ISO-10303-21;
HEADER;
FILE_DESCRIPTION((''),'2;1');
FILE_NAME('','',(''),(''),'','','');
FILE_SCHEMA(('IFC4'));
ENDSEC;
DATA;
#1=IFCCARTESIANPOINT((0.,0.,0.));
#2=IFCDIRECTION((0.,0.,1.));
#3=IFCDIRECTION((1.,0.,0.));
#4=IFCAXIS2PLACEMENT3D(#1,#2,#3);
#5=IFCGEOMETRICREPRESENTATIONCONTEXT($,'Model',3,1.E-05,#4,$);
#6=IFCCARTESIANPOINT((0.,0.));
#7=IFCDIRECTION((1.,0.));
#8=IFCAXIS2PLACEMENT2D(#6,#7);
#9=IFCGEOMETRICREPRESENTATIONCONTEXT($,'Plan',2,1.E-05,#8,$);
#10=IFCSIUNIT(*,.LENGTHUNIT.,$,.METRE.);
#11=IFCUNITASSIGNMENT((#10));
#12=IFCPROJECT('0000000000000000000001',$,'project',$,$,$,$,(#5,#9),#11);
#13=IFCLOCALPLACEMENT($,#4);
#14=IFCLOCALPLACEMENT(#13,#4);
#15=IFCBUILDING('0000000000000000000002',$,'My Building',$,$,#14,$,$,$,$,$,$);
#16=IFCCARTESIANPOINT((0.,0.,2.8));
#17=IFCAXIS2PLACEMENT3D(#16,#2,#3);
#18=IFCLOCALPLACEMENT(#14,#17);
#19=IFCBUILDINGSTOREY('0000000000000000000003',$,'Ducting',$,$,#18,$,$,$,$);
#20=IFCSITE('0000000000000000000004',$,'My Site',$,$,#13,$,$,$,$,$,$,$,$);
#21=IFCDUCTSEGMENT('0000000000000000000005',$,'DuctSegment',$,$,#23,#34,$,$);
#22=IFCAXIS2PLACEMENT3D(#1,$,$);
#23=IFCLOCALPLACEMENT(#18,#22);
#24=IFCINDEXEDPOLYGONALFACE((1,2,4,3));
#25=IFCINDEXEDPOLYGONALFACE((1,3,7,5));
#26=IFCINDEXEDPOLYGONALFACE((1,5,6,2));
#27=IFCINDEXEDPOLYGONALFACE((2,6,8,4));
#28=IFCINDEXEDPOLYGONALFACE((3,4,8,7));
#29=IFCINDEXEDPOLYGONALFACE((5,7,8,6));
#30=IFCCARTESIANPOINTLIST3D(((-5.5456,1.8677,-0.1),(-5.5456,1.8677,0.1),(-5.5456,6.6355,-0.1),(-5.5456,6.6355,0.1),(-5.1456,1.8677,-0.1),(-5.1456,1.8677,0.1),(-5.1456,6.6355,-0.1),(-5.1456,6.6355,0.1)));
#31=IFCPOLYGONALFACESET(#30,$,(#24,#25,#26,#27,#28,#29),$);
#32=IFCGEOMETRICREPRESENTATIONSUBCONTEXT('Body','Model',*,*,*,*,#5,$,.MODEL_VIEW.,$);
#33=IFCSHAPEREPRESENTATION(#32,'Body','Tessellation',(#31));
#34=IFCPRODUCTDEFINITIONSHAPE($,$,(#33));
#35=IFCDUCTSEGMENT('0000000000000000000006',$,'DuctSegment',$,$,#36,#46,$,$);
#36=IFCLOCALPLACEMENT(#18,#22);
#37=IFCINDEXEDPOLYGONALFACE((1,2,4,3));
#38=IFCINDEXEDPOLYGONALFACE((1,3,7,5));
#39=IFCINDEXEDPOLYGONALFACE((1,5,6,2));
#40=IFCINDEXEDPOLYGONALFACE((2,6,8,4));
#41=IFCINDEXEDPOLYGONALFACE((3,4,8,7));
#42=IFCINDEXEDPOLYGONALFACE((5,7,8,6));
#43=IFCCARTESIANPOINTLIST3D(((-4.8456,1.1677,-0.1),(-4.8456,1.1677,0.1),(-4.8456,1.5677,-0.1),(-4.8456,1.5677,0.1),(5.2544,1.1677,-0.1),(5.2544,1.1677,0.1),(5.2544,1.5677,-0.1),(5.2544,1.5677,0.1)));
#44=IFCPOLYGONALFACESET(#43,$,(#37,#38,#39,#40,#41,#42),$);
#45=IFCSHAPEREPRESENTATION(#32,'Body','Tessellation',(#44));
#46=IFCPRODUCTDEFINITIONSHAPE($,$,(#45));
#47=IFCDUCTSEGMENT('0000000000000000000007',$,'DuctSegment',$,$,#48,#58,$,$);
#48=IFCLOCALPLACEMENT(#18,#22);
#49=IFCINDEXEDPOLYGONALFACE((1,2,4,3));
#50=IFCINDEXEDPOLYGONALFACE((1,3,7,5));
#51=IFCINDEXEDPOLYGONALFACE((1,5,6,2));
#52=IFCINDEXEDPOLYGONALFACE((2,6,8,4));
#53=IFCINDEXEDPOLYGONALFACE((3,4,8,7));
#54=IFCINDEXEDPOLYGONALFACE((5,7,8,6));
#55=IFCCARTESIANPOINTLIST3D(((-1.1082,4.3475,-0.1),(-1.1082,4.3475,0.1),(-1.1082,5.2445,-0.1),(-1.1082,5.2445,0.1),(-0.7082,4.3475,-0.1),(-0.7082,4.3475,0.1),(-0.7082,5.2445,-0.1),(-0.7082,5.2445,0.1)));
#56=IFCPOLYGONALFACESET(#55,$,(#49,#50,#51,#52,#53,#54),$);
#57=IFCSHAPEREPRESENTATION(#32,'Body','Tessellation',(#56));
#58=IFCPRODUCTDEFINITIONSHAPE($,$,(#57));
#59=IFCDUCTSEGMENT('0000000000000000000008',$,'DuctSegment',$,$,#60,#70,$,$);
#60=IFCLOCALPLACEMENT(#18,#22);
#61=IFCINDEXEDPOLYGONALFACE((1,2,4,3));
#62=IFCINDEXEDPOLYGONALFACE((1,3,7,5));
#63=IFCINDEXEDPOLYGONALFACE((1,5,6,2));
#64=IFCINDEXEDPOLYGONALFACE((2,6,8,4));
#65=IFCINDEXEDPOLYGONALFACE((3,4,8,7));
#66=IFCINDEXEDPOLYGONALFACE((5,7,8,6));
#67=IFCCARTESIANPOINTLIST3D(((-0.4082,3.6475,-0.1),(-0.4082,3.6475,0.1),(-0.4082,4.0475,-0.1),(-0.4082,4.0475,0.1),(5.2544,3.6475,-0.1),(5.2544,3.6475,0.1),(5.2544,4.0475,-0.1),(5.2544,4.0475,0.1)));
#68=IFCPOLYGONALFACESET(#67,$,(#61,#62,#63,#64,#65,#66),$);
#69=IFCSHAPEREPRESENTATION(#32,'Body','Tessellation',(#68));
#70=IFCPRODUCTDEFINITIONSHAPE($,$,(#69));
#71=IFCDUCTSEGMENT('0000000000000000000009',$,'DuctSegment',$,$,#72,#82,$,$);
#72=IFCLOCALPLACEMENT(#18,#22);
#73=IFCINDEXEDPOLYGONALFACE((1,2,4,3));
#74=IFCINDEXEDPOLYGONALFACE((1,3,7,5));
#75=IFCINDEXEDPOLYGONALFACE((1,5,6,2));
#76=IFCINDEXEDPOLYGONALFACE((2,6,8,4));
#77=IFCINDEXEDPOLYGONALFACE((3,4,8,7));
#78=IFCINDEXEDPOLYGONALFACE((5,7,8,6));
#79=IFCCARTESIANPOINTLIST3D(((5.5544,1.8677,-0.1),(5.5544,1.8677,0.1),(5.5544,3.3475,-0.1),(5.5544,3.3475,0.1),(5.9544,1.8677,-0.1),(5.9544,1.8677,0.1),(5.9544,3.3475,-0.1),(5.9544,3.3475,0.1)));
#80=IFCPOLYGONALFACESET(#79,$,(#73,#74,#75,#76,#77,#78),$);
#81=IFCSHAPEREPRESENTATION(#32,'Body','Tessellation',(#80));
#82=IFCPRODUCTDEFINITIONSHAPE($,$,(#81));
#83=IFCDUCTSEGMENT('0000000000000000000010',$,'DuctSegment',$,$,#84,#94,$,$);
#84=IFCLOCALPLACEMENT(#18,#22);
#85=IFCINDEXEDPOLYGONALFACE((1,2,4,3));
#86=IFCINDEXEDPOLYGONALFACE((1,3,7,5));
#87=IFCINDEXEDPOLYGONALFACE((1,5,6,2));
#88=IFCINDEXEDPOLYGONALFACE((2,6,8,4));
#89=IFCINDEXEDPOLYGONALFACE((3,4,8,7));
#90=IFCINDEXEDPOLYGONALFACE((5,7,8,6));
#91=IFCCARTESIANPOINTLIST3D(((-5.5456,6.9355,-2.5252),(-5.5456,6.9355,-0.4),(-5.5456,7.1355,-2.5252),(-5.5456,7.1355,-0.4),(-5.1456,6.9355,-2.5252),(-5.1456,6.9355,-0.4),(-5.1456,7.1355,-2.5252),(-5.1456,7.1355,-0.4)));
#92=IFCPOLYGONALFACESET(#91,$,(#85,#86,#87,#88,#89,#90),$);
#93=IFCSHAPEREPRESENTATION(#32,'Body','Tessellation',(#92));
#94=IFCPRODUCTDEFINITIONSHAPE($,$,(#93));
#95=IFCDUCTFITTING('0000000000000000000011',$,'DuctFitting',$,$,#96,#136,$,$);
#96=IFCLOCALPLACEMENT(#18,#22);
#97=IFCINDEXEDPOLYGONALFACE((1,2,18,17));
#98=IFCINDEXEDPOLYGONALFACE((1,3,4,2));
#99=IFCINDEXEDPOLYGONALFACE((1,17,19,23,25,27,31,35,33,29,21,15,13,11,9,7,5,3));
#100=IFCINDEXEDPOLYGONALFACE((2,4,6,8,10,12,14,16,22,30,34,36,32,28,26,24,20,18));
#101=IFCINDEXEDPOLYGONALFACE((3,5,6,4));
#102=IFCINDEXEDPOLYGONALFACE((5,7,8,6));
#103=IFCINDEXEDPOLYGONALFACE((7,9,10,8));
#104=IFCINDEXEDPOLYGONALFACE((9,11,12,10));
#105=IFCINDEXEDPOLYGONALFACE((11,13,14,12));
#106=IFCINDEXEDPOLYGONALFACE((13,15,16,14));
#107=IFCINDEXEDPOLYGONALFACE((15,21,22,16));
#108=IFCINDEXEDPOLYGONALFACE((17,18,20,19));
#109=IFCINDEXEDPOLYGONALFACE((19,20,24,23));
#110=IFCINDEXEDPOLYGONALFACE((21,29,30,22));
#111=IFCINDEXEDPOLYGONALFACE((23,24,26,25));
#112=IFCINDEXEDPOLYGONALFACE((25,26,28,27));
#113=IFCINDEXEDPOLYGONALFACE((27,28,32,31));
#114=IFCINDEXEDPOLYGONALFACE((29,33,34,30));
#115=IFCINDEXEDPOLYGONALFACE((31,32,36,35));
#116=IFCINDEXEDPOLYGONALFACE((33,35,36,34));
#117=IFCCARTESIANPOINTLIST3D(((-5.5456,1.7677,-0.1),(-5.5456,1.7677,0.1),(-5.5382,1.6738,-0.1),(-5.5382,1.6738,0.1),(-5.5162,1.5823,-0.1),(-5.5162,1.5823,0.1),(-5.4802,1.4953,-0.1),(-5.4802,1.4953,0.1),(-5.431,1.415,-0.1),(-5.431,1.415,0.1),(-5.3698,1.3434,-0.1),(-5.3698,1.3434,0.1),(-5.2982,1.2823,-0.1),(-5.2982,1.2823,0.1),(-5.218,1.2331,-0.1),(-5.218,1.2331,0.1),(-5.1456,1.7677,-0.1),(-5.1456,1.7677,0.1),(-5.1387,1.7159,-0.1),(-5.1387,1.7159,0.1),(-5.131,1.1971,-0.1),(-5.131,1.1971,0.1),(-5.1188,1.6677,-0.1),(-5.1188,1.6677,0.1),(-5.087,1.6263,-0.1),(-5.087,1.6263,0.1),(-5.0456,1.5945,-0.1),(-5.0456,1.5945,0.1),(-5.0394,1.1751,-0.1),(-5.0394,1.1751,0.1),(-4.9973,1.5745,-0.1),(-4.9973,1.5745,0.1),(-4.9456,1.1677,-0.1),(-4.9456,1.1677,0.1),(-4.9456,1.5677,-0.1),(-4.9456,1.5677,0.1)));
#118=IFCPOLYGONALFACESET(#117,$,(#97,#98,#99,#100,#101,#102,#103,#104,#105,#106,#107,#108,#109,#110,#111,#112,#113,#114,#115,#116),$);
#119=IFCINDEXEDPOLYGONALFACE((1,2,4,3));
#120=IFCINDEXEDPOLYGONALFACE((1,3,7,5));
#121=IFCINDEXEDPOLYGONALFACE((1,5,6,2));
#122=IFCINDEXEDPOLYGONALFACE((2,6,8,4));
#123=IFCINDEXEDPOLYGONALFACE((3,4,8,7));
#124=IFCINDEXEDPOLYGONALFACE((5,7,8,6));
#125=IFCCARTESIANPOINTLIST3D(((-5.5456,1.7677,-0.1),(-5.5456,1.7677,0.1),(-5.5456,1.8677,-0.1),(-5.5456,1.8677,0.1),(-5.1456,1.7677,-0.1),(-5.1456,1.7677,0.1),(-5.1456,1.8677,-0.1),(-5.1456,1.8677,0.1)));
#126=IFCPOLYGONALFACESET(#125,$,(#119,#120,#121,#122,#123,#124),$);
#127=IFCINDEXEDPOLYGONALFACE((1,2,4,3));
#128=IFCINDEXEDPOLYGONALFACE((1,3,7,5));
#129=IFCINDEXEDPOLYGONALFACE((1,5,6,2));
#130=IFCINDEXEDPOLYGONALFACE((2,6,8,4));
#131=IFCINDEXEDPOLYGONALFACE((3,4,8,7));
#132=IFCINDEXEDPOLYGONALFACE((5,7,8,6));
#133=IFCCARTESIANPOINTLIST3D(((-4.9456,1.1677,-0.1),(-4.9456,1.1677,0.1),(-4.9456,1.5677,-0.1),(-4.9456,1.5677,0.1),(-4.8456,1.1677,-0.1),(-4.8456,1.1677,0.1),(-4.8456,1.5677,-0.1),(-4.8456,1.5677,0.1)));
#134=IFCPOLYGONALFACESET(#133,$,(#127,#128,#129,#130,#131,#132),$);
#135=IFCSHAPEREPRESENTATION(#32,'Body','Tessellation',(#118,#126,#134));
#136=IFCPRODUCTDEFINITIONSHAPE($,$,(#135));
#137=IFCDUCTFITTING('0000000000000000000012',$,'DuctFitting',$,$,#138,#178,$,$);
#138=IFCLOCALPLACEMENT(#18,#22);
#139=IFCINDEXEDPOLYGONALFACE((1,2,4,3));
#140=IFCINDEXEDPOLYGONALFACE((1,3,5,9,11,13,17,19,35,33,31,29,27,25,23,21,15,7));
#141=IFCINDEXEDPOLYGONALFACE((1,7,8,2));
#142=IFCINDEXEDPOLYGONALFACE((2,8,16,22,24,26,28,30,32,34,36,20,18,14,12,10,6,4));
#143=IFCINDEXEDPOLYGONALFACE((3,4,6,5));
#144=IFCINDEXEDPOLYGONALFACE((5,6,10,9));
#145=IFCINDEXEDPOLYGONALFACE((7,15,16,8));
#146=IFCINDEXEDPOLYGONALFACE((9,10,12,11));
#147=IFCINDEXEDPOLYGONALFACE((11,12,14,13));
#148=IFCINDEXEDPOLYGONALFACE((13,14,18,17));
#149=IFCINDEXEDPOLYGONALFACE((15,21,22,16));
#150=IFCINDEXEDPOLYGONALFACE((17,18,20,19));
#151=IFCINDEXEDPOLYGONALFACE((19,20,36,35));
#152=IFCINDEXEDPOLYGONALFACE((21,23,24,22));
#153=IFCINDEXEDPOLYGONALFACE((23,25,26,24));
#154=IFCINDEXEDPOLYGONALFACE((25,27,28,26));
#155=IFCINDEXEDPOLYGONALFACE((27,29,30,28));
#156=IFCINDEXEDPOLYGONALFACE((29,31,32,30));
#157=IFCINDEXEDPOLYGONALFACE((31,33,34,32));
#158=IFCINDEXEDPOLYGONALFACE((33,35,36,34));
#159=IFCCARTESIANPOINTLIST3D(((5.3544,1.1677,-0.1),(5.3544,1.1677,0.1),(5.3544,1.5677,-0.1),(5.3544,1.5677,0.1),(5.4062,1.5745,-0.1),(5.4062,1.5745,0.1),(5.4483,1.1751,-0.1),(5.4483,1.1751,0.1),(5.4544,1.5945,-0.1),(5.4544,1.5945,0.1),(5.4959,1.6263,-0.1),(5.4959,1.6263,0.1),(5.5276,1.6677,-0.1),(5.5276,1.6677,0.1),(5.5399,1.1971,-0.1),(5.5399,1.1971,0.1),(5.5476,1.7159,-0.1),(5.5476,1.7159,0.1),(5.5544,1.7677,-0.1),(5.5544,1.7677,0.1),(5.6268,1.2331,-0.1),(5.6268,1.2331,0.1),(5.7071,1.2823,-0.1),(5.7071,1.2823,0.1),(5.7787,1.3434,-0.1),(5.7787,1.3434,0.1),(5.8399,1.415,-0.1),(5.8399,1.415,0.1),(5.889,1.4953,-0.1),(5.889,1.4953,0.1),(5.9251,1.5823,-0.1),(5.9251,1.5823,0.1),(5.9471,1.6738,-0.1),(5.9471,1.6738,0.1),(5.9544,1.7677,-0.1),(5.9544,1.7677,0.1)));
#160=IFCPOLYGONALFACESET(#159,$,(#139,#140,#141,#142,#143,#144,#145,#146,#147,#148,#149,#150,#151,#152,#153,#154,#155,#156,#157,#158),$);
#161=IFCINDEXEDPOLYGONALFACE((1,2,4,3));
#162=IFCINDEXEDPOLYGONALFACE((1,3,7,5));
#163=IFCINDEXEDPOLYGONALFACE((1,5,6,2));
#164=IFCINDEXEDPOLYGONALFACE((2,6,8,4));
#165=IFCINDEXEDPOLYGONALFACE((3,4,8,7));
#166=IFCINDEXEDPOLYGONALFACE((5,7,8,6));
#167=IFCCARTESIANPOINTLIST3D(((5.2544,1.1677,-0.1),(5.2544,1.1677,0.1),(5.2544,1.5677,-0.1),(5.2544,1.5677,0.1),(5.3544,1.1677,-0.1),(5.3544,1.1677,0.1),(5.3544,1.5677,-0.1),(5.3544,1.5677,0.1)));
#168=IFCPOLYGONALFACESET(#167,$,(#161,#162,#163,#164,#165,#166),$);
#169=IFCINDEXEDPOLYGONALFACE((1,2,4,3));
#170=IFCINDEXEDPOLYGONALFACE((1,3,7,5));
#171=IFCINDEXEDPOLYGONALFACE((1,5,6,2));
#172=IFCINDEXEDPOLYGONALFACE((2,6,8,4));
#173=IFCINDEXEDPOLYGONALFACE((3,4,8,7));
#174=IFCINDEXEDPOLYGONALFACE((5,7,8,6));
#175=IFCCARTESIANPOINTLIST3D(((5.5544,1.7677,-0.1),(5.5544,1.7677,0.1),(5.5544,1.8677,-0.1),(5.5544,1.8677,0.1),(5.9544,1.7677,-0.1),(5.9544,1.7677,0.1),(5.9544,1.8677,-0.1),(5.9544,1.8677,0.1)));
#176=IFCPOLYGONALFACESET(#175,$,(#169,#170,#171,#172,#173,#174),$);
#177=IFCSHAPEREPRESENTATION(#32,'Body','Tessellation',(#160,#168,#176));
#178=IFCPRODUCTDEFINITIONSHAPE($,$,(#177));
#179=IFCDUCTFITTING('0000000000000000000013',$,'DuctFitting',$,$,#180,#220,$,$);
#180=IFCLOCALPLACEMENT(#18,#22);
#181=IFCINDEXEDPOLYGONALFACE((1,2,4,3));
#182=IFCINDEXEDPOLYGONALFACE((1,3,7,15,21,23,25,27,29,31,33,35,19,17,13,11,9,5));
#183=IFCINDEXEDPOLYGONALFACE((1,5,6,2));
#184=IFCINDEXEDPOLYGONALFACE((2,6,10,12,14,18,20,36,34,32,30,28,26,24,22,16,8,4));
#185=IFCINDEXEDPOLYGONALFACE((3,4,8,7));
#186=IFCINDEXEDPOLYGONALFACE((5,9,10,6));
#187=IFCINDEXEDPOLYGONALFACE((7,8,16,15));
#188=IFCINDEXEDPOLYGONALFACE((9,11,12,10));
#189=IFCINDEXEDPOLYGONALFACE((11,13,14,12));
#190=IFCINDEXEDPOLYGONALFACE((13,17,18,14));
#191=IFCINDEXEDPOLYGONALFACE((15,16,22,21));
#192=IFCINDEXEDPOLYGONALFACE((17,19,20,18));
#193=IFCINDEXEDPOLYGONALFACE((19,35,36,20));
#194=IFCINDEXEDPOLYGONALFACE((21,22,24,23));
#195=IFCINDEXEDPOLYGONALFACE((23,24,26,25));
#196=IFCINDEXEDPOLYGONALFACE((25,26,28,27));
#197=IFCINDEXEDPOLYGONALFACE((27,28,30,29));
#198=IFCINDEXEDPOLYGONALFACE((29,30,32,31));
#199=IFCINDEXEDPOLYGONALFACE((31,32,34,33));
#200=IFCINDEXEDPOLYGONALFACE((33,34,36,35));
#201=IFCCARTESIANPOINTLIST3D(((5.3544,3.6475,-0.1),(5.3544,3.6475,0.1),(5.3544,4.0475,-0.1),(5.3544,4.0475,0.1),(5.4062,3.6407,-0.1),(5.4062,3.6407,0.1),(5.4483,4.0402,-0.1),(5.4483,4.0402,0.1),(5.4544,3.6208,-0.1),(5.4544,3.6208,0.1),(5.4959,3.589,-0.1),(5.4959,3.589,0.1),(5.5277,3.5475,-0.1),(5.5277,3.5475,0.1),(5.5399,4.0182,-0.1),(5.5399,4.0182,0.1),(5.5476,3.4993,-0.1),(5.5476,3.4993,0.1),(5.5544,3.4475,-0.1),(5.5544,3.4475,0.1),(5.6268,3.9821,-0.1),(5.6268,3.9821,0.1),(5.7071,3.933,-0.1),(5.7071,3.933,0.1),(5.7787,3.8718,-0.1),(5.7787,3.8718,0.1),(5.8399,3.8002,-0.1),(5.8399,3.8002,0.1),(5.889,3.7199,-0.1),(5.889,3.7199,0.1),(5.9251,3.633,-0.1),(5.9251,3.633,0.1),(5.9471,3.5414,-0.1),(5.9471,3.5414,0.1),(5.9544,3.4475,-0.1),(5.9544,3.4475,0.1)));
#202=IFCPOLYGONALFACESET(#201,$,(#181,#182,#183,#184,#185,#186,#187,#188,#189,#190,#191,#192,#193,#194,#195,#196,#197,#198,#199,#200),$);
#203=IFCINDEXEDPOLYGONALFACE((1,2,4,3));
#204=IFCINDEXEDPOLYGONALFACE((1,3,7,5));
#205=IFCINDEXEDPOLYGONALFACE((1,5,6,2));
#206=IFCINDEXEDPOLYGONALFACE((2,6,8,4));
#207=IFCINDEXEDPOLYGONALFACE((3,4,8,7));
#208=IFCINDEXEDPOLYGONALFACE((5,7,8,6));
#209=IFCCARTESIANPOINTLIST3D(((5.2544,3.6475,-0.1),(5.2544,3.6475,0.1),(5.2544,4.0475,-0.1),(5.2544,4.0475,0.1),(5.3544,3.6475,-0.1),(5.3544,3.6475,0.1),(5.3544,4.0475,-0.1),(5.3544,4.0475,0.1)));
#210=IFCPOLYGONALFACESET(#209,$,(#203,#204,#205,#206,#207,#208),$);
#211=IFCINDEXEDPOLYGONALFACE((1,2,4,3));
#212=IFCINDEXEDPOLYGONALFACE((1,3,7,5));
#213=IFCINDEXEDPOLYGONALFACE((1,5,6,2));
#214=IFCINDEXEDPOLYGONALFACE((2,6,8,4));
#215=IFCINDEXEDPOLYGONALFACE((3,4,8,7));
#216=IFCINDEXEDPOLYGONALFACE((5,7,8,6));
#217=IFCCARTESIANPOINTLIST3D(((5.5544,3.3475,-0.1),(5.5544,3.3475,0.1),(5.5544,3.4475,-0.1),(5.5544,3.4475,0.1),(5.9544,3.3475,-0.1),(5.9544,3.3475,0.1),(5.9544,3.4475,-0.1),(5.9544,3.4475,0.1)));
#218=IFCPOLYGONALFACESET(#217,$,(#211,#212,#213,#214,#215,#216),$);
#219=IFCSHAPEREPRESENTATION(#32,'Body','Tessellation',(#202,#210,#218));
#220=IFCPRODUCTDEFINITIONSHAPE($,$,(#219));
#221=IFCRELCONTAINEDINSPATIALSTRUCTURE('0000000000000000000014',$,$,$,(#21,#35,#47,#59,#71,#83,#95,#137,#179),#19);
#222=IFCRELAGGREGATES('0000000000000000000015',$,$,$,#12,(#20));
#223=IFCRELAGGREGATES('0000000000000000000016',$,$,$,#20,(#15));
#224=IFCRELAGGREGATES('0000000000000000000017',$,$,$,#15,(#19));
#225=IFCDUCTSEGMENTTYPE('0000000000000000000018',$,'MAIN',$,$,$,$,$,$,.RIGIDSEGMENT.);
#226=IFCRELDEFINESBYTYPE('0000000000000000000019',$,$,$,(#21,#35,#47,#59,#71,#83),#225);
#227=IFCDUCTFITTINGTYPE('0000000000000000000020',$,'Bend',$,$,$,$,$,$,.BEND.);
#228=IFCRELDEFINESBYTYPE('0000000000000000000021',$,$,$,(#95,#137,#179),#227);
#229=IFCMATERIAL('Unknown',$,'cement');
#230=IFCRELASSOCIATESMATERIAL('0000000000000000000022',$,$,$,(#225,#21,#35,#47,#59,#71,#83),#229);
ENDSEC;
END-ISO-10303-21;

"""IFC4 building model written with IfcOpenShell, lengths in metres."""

from ifc_helpers import new_model, si_unit, frame, origin_with_axes, origin_2d_with_axis, place, context, subcontext, project, spatial, line, arc, indexed_curve, rectangle, outline, extrude, source, transform, mapped, material, material_profile, profile_set, profile_usage, type_object, type_shapes, element, save


model = new_model("IFC4")

# Units and contexts
model_context = context("Model", 3, precision=1e-05, world=origin_with_axes())
plan_context = context("Plan", 2, precision=1e-05, world=origin_2d_with_axis())
body_context = subcontext(model_context, "Body", "Model", "MODEL_VIEW")
ifc_project = project(units=[si_unit("LENGTHUNIT", "METRE")], contexts=[model_context, plan_context])

# Site, building, storey
site_placement = place(None, origin_with_axes())
site = spatial("IfcSite", under=ifc_project, at=site_placement, Name="My Site")
building_placement = place(site_placement, origin_with_axes())
building = spatial("IfcBuilding", under=site, at=building_placement, Name="My Building")
storey_placement = place(building_placement, frame((0.0, 0.0, 2.8), z_axis=(0.0, 0.0, 1.0), x_axis=(1.0, 0.0, 0.0)))
storey = spatial("IfcBuildingStorey", under=building, at=storey_placement, Name="Ducting")

# Duct segments
ifc_material = material(Name="Unknown", Category="cement")
ifc_material_profile_1 = material_profile(ifc_material, rectangle(XDim=0.4, YDim=0.2))
ifc_profile_set_1 = profile_set([ifc_material_profile_1])
ifc_profile_usage_1 = profile_usage(ifc_profile_set_1, cardinal=5)
duct_segment_type_1 = type_object("IfcDuctSegmentType", Name="MAIN", PredefinedType="RIGIDSEGMENT", material=ifc_profile_set_1)
duct_segment_1_placement = place(storey_placement, frame((-5.3456, 6.6355, 0.0), z_axis=(0.0, -1.0, 0.0), x_axis=(1.0, 0.0, 0.0)))
element("IfcDuctSegment", 1, at=duct_segment_1_placement, inside=storey, type_object=duct_segment_type_1, material=ifc_profile_usage_1, Name="DuctSegment", context=body_context, shape_type="SweptSolid", body=[
    extrude(rectangle(XDim=0.4, YDim=0.2), origin_with_axes(), (0.0, 0.0, 1.0), 4.7678),
])
ifc_profile_usage_2 = profile_usage(ifc_profile_set_1, cardinal=5)
duct_segment_2_placement = place(storey_placement, frame((-4.8456, 1.3677, 0.0), z_axis=(1.0, -0.000001, 0.000001), x_axis=(0.000001, 1.0, 0.0)))
element("IfcDuctSegment", 2, at=duct_segment_2_placement, inside=storey, type_object=duct_segment_type_1, material=ifc_profile_usage_2, Name="DuctSegment", context=body_context, shape_type="SweptSolid", body=[
    extrude(rectangle(XDim=0.4, YDim=0.2), origin_with_axes(), (0.0, 0.0, 1.0), 10.1),
])
ifc_profile_usage_3 = profile_usage(ifc_profile_set_1, cardinal=5)
duct_segment_3_placement = place(storey_placement, frame((-0.9082, 5.2445, 0.0), z_axis=(0.0, -1.0, 0.0), x_axis=(1.0, 0.0, 0.0)))
element("IfcDuctSegment", 3, at=duct_segment_3_placement, inside=storey, type_object=duct_segment_type_1, material=ifc_profile_usage_3, Name="DuctSegment", context=body_context, shape_type="SweptSolid", body=[
    extrude(rectangle(XDim=0.4, YDim=0.2), origin_with_axes(), (0.0, 0.0, 1.0), 0.897),
])
ifc_profile_usage_4 = profile_usage(ifc_profile_set_1, cardinal=5)
duct_segment_4_placement = place(storey_placement, frame((-0.4082, 3.8475, 0.0), z_axis=(1.0, 0.0, 0.0), x_axis=(0.0, 1.0, 0.0)))
element("IfcDuctSegment", 4, at=duct_segment_4_placement, inside=storey, type_object=duct_segment_type_1, material=ifc_profile_usage_4, Name="DuctSegment", context=body_context, shape_type="SweptSolid", body=[
    extrude(rectangle(XDim=0.4, YDim=0.2), origin_with_axes(), (0.0, 0.0, 1.0), 5.6627),
])
ifc_profile_usage_5 = profile_usage(ifc_profile_set_1, cardinal=5)
duct_segment_5_placement = place(storey_placement, frame((5.7544, 3.3475, 0.0), z_axis=(0.0, -1.0, 0.0), x_axis=(1.0, 0.0, 0.0)))
element("IfcDuctSegment", 5, at=duct_segment_5_placement, inside=storey, type_object=duct_segment_type_1, material=ifc_profile_usage_5, Name="DuctSegment", context=body_context, shape_type="SweptSolid", body=[
    extrude(rectangle(XDim=0.4, YDim=0.2), origin_with_axes(), (0.0, 0.0, 1.0), 1.4799),
])
ifc_profile_usage_6 = profile_usage(ifc_profile_set_1, cardinal=5)
duct_segment_6_placement = place(storey_placement, frame((-5.3456, 7.0355, -0.4), z_axis=(0.0, 0.0, -1.0), x_axis=(1.0, 0.0, 0.0)))
element("IfcDuctSegment", 6, at=duct_segment_6_placement, inside=storey, type_object=duct_segment_type_1, material=ifc_profile_usage_6, Name="DuctSegment", context=body_context, shape_type="SweptSolid", body=[
    extrude(rectangle(XDim=0.4, YDim=0.2), origin_with_axes(), (0.0, 0.0, 1.0), 2.1252),
])

# Duct fittings
duct_fitting_type_1 = type_object("IfcDuctFittingType", Name="Bend", PredefinedType="BEND")
shared_shape = source(origin_with_axes(), body_context, "Body", "SweptSolid", [
    extrude(outline(indexed_curve([(0.2, 0.0), (0.2586, 0.1414), (0.4, 0.2), (0.4, 0.6), (-0.0243, 0.4243), (-0.2, 0.0)], segments=[arc(1, 2, 3), line(3, 4), arc(4, 5, 6), line(6, 1)])), frame((0.0, -0.1, 0.1), z_axis=(0.0, -1.0, 0.0), x_axis=(1.0, 0.0, 0.0)), (0.0, 0.0, -1.0), 0.2),
    extrude(rectangle(XDim=0.4, YDim=0.2), origin_with_axes(), (0.0, 0.0, 1.0), 0.1),
    extrude(rectangle(XDim=0.4, YDim=0.2), frame((0.4, 0.0, 0.5), z_axis=(1.0, 0.0, 0.000001), x_axis=(-0.000001, 0.0, 1.0)), (0.0, 0.0, 1.0), 0.1),
])
type_shapes(duct_fitting_type_1, [shared_shape])
for number, where, z_axis, x_axis, name in (
    (7, (-5.3456, 1.8677, 0.0), (0.0, -1.0, 0.0), (1.0, 0.0, 0.0), "DuctFitting"),
    (8, (5.2544, 1.3677, 0.0), (1.0, -0.000001, 0.000001), (0.000001, 1.0, 0.0), "DuctFitting"),
    (9, (5.2544, 3.8475, 0.0), (1.0, 0.0, 0.0), (0.0, -1.0, 0.0), "DuctFitting"),
):
    element("IfcDuctFitting", number, at=place(storey_placement, frame(where, z_axis=z_axis, x_axis=x_axis)), inside=storey, type_object=duct_fitting_type_1, Name=name, context=body_context, shape_type="MappedRepresentation", body=[
        mapped(shared_shape, transform((0.0, 0.0, 0.0), x_axis=(1.0, 0.0, 0.0), y_axis=(0.0, 1.0, 0.0), z_axis=(0.0, 0.0, 1.0), scale=1.0)),
    ])

save(model, "model.ifc")
